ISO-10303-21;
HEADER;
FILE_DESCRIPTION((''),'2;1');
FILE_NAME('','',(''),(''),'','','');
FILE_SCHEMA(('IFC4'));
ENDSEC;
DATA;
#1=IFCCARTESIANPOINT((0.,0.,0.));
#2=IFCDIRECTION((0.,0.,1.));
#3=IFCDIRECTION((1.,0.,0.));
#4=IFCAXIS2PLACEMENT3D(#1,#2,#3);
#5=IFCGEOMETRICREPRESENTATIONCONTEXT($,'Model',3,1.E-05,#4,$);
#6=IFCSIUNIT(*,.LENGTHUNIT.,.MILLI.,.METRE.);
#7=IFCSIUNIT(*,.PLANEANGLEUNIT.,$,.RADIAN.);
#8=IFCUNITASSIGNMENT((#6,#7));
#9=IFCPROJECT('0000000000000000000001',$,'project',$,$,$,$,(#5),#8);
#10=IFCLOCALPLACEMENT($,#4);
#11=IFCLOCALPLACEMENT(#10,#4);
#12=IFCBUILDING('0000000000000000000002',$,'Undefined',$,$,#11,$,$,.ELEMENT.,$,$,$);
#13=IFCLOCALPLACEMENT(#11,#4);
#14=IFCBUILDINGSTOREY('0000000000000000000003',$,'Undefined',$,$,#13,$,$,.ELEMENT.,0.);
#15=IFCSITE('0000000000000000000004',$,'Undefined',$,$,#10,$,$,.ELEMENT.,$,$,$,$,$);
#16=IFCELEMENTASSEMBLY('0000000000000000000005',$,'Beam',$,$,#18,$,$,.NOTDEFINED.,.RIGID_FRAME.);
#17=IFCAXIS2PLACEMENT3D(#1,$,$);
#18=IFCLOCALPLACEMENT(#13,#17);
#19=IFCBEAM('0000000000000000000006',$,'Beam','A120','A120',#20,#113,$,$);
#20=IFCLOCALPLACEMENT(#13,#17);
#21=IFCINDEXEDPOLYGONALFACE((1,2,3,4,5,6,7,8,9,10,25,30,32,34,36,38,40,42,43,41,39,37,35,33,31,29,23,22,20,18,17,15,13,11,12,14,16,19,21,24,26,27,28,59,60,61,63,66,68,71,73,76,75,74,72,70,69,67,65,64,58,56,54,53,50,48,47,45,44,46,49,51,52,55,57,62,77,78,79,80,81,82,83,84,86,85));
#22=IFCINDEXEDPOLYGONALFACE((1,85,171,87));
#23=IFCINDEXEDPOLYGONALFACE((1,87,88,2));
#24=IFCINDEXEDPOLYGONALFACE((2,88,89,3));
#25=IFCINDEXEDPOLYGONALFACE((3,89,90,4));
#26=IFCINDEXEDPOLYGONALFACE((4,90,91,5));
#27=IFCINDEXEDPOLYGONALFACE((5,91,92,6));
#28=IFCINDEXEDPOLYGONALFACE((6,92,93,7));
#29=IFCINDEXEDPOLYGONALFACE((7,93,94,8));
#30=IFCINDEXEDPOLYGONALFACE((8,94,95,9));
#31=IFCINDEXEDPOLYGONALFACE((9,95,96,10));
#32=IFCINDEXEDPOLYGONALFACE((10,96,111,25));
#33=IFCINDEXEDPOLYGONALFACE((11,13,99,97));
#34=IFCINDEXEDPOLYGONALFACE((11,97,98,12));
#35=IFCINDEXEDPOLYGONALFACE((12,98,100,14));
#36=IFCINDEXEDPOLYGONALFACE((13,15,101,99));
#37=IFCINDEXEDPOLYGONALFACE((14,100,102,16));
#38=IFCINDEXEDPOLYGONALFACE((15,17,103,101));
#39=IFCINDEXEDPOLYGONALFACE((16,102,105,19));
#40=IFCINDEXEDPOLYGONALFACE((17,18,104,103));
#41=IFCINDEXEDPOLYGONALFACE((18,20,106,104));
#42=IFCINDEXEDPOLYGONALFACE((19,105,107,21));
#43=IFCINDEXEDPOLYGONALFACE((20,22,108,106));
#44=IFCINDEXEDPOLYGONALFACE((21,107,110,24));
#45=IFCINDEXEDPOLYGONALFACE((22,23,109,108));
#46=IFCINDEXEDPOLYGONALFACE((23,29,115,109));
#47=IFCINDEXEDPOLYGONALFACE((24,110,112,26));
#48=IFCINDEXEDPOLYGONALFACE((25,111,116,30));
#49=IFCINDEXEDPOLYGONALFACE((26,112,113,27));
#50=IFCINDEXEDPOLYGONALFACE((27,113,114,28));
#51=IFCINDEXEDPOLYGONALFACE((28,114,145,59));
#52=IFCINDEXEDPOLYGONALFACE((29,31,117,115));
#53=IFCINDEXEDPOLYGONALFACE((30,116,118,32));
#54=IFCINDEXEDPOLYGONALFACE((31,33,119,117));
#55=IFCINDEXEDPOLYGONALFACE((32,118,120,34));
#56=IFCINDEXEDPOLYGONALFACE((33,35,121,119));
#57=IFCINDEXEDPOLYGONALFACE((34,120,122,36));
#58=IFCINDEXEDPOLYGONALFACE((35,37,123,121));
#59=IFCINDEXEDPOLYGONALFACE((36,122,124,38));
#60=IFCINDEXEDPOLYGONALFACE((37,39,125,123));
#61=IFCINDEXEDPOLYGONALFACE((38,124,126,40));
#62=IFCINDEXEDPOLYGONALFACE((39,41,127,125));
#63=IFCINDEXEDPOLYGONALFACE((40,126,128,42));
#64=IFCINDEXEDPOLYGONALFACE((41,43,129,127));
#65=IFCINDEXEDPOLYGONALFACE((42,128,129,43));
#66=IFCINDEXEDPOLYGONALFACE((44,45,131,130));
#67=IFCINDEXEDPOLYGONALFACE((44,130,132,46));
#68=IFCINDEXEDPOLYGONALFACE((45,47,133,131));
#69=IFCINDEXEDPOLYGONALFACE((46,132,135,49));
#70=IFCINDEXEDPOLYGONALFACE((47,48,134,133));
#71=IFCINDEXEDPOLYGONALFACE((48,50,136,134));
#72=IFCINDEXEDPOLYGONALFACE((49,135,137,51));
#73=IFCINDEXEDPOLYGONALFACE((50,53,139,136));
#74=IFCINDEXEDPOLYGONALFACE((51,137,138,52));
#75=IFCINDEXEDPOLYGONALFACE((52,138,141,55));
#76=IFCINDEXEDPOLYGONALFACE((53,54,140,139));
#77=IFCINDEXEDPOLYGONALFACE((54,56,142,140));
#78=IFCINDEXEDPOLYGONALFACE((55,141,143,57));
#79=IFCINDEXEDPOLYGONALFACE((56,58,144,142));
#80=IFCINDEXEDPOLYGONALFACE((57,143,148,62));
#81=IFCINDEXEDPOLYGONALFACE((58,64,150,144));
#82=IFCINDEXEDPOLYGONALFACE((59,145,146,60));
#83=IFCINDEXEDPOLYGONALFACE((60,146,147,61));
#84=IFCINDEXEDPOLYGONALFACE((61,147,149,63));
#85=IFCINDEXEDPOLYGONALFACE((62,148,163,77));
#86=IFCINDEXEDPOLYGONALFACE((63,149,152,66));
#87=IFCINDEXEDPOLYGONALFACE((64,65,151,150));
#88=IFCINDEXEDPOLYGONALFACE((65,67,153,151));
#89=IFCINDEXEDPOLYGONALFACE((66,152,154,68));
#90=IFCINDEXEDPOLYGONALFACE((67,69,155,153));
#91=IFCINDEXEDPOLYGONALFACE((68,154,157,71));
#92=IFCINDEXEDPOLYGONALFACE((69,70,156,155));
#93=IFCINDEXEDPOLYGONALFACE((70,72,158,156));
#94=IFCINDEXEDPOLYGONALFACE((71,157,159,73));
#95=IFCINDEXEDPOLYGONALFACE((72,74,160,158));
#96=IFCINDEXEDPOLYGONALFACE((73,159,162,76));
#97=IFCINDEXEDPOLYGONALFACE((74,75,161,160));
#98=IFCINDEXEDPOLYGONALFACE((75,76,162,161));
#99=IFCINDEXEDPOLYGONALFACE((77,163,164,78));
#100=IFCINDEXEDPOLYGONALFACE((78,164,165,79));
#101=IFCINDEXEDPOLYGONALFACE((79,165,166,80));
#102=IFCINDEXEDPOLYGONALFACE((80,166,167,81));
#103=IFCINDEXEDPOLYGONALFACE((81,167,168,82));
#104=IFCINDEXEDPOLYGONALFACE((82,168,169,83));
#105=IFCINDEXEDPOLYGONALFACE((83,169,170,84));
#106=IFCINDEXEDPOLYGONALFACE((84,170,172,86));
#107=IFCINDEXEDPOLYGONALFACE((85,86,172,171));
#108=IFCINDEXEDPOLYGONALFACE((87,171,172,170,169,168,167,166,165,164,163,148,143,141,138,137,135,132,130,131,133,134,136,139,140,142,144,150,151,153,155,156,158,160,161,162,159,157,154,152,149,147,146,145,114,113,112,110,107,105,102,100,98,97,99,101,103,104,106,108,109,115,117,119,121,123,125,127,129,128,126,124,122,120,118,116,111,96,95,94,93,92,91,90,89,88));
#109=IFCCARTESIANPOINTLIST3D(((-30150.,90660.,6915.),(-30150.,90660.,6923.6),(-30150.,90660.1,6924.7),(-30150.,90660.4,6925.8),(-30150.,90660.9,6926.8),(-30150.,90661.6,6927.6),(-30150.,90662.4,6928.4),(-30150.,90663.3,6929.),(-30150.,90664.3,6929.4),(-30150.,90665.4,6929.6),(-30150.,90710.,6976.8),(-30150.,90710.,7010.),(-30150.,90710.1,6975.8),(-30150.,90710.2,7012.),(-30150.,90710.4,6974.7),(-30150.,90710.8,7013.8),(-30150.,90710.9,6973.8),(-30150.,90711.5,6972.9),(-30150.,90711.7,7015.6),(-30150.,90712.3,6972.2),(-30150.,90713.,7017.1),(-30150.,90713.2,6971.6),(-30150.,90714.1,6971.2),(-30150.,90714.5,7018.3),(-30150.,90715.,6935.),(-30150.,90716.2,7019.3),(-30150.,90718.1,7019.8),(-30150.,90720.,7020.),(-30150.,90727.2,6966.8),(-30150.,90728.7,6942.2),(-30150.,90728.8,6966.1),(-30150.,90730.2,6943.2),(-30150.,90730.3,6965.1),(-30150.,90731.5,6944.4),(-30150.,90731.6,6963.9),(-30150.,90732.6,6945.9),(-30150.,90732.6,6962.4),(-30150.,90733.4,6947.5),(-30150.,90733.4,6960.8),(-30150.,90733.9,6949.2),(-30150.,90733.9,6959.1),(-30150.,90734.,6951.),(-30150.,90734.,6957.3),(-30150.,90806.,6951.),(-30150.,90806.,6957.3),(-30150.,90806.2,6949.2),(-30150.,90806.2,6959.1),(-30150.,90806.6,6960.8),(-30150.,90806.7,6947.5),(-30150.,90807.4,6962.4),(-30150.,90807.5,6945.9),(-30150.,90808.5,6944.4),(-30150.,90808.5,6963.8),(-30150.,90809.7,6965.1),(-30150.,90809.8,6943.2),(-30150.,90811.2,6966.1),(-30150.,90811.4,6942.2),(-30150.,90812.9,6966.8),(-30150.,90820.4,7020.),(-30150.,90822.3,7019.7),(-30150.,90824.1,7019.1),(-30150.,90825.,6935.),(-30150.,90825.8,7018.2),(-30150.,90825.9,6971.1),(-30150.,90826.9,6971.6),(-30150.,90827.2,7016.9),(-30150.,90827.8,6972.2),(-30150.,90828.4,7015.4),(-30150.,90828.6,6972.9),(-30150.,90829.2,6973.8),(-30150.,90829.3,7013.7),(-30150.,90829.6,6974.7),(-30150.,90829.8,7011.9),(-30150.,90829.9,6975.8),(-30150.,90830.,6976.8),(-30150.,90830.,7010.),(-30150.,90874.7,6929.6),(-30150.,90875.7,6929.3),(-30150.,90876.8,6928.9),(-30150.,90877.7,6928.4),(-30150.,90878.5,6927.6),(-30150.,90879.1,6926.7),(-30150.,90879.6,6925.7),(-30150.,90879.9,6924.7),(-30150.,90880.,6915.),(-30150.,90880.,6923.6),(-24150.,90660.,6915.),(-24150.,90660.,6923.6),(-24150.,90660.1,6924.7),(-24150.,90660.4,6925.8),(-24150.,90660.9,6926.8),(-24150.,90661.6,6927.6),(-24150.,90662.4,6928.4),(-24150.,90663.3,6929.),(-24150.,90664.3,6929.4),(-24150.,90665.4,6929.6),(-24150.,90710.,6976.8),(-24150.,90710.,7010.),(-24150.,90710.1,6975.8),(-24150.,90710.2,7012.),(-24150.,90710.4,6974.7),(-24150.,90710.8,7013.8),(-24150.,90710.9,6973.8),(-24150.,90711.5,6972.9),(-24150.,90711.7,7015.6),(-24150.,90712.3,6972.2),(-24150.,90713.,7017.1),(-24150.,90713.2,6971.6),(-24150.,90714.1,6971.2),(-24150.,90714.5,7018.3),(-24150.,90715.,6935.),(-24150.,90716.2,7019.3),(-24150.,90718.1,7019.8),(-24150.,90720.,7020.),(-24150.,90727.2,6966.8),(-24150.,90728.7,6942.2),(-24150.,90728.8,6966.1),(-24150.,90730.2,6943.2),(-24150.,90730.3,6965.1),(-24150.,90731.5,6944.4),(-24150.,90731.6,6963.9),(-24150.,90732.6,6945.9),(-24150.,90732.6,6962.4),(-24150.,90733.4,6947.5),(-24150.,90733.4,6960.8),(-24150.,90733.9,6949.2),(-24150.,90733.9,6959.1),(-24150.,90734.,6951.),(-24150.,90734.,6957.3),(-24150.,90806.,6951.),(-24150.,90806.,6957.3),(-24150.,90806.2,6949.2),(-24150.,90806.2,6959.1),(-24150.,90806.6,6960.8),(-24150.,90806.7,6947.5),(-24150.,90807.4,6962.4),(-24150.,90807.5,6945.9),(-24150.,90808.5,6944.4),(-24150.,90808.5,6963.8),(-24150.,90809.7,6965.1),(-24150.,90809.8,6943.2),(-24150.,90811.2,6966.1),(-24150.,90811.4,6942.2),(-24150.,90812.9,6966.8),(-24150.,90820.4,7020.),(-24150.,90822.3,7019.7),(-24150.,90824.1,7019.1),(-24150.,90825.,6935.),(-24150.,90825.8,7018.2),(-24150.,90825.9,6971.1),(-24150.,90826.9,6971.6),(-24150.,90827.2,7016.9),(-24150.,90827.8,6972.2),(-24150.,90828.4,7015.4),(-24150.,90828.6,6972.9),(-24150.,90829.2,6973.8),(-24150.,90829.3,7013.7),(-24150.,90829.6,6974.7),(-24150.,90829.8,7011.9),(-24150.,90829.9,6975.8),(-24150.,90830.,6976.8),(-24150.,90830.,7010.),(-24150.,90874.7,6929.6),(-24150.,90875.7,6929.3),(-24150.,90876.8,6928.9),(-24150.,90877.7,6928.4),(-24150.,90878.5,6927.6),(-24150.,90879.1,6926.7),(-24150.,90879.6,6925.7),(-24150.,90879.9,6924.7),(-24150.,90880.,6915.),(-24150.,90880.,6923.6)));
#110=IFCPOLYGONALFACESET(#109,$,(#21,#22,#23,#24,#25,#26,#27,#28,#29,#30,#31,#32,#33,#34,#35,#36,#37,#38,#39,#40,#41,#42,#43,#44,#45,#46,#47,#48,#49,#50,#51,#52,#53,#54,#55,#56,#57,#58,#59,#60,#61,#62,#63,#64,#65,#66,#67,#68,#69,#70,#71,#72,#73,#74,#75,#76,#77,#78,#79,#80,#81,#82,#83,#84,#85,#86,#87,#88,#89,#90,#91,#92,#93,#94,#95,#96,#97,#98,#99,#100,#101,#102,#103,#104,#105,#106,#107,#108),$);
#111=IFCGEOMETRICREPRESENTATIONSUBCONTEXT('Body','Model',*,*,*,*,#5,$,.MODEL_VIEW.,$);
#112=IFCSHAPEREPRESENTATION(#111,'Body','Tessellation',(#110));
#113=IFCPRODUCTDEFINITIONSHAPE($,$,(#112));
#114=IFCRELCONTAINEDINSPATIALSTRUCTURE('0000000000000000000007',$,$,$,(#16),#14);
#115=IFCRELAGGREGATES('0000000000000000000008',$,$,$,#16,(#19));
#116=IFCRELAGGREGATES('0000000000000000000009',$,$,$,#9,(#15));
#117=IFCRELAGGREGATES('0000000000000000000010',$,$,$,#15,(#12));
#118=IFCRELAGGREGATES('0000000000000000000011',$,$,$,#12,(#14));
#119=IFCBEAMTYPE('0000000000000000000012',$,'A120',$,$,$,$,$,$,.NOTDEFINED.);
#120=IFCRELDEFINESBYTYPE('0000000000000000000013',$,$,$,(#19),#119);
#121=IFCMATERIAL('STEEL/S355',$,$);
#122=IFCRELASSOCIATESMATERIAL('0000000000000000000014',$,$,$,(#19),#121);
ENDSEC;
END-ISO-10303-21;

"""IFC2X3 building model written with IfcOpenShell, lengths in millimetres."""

from ifc_helpers import new_model, si_unit, frame, origin_with_axes, place, context, subcontext, project, spatial, polyline, outline, extrude, material, type_object, element, aggregate, save


model = new_model("IFC2X3")

# Units and contexts
model_context = context("Model", 3, precision=1e-05, world=origin_with_axes())
body_context = subcontext(model_context, "Body", "Model", "MODEL_VIEW")
ifc_project = project(units=[si_unit("LENGTHUNIT", "METRE", prefix="MILLI"), si_unit("PLANEANGLEUNIT", "RADIAN")], contexts=[model_context])

# Site, building, storey
site_placement = place(None, origin_with_axes())
site = spatial("IfcSite", under=ifc_project, at=site_placement, Name="Undefined", CompositionType="ELEMENT")
building_placement = place(site_placement, origin_with_axes())
building = spatial("IfcBuilding", under=site, at=building_placement, Name="Undefined", CompositionType="ELEMENT")
storey_placement = place(building_placement, origin_with_axes())
storey = spatial("IfcBuildingStorey", under=building, at=storey_placement, Name="Undefined", CompositionType="ELEMENT", Elevation=0.0)

# Element assembly, beam
ifc_material_1 = material(Name="STEEL/S355")
beam_type_1 = type_object("IfcBeamType", Name="A120", PredefinedType="NOTDEFINED")
assembly_1_placement = place(storey_placement, origin_with_axes())
assembly_1 = element("IfcElementAssembly", 1, at=assembly_1_placement, inside=storey, Name="Beam", AssemblyPlace="NOTDEFINED", PredefinedType="RIGID_FRAME")
beam_1_placement = place(assembly_1_placement, frame((-30150.0, 90770.0, 6967.5), z_axis=(0.0, 0.000118, 1.0), x_axis=(1.0, 0.0, 0.0)))
beam_1 = element("IfcBeam", 2, at=beam_1_placement, type_object=beam_type_1, material=ifc_material_1, Name="Beam", Description="A120", ObjectType="A120", context=body_context, shape_type="SweptSolid", body=[
    extrude(outline(polyline([(-110.0, -52.5), (-110.0, -43.9), (-109.9, -42.8), (-109.6, -41.8), (-109.1, -40.8), (-108.5, -39.9), (-107.7, -39.1), (-106.7, -38.6), (-105.7, -38.2), (-104.7, -37.9), (-55.0, -32.5), (-41.3, -25.3), (-39.8, -24.3), (-38.5, -23.1), (-37.4, -21.6), (-36.6, -20.0), (-36.2, -18.3), (-36.0, -16.5), (-36.0, -10.2), (-36.1, -8.4), (-36.6, -6.7), (-37.4, -5.1), (-38.4, -3.7), (-39.7, -2.4), (-41.2, -1.4), (-42.8, -0.7), (-55.9, 3.6), (-56.9, 4.1), (-57.8, 4.7), (-58.5, 5.4), (-59.2, 6.3), (-59.6, 7.2), (-59.9, 8.3), (-60.0, 9.3), (-60.0, 42.5), (-59.8, 44.4), (-59.3, 46.2), (-58.4, 47.9), (-57.2, 49.4), (-55.7, 50.7), (-54.1, 51.6), (-52.3, 52.2), (-50.4, 52.5), (50.0, 52.5), (51.9, 52.3), (53.8, 51.7), (55.5, 50.8), (57.1, 49.6), (58.3, 48.1), (59.2, 46.3), (59.8, 44.4), (60.0, 42.5), (60.0, 9.3), (59.9, 8.3), (59.6, 7.2), (59.2, 6.3), (58.5, 5.4), (57.8, 4.7), (56.9, 4.1), (55.9, 3.6), (42.8, -0.7), (41.2, -1.4), (39.7, -2.4), (38.4, -3.7), (37.4, -5.1), (36.6, -6.7), (36.1, -8.4), (36.0, -10.2), (36.0, -16.5), (36.2, -18.3), (36.6, -20.0), (37.4, -21.6), (38.5, -23.1), (39.8, -24.3), (41.3, -25.3), (55.0, -32.5), (104.7, -37.9), (105.7, -38.2), (106.7, -38.6), (107.7, -39.1), (108.5, -39.9), (109.1, -40.8), (109.6, -41.8), (109.9, -42.8), (110.0, -43.9), (110.0, -52.5), (-110.0, -52.5)])), frame((6000.0, 0.0, 0.0), z_axis=(-1.0, 0.0, 0.0), x_axis=(0.0, -1.0, 0.0)), (0.0, 0.0, 1.0), 6000.0),
])
aggregate(assembly_1, [beam_1])

save(model, "model.ifc")
